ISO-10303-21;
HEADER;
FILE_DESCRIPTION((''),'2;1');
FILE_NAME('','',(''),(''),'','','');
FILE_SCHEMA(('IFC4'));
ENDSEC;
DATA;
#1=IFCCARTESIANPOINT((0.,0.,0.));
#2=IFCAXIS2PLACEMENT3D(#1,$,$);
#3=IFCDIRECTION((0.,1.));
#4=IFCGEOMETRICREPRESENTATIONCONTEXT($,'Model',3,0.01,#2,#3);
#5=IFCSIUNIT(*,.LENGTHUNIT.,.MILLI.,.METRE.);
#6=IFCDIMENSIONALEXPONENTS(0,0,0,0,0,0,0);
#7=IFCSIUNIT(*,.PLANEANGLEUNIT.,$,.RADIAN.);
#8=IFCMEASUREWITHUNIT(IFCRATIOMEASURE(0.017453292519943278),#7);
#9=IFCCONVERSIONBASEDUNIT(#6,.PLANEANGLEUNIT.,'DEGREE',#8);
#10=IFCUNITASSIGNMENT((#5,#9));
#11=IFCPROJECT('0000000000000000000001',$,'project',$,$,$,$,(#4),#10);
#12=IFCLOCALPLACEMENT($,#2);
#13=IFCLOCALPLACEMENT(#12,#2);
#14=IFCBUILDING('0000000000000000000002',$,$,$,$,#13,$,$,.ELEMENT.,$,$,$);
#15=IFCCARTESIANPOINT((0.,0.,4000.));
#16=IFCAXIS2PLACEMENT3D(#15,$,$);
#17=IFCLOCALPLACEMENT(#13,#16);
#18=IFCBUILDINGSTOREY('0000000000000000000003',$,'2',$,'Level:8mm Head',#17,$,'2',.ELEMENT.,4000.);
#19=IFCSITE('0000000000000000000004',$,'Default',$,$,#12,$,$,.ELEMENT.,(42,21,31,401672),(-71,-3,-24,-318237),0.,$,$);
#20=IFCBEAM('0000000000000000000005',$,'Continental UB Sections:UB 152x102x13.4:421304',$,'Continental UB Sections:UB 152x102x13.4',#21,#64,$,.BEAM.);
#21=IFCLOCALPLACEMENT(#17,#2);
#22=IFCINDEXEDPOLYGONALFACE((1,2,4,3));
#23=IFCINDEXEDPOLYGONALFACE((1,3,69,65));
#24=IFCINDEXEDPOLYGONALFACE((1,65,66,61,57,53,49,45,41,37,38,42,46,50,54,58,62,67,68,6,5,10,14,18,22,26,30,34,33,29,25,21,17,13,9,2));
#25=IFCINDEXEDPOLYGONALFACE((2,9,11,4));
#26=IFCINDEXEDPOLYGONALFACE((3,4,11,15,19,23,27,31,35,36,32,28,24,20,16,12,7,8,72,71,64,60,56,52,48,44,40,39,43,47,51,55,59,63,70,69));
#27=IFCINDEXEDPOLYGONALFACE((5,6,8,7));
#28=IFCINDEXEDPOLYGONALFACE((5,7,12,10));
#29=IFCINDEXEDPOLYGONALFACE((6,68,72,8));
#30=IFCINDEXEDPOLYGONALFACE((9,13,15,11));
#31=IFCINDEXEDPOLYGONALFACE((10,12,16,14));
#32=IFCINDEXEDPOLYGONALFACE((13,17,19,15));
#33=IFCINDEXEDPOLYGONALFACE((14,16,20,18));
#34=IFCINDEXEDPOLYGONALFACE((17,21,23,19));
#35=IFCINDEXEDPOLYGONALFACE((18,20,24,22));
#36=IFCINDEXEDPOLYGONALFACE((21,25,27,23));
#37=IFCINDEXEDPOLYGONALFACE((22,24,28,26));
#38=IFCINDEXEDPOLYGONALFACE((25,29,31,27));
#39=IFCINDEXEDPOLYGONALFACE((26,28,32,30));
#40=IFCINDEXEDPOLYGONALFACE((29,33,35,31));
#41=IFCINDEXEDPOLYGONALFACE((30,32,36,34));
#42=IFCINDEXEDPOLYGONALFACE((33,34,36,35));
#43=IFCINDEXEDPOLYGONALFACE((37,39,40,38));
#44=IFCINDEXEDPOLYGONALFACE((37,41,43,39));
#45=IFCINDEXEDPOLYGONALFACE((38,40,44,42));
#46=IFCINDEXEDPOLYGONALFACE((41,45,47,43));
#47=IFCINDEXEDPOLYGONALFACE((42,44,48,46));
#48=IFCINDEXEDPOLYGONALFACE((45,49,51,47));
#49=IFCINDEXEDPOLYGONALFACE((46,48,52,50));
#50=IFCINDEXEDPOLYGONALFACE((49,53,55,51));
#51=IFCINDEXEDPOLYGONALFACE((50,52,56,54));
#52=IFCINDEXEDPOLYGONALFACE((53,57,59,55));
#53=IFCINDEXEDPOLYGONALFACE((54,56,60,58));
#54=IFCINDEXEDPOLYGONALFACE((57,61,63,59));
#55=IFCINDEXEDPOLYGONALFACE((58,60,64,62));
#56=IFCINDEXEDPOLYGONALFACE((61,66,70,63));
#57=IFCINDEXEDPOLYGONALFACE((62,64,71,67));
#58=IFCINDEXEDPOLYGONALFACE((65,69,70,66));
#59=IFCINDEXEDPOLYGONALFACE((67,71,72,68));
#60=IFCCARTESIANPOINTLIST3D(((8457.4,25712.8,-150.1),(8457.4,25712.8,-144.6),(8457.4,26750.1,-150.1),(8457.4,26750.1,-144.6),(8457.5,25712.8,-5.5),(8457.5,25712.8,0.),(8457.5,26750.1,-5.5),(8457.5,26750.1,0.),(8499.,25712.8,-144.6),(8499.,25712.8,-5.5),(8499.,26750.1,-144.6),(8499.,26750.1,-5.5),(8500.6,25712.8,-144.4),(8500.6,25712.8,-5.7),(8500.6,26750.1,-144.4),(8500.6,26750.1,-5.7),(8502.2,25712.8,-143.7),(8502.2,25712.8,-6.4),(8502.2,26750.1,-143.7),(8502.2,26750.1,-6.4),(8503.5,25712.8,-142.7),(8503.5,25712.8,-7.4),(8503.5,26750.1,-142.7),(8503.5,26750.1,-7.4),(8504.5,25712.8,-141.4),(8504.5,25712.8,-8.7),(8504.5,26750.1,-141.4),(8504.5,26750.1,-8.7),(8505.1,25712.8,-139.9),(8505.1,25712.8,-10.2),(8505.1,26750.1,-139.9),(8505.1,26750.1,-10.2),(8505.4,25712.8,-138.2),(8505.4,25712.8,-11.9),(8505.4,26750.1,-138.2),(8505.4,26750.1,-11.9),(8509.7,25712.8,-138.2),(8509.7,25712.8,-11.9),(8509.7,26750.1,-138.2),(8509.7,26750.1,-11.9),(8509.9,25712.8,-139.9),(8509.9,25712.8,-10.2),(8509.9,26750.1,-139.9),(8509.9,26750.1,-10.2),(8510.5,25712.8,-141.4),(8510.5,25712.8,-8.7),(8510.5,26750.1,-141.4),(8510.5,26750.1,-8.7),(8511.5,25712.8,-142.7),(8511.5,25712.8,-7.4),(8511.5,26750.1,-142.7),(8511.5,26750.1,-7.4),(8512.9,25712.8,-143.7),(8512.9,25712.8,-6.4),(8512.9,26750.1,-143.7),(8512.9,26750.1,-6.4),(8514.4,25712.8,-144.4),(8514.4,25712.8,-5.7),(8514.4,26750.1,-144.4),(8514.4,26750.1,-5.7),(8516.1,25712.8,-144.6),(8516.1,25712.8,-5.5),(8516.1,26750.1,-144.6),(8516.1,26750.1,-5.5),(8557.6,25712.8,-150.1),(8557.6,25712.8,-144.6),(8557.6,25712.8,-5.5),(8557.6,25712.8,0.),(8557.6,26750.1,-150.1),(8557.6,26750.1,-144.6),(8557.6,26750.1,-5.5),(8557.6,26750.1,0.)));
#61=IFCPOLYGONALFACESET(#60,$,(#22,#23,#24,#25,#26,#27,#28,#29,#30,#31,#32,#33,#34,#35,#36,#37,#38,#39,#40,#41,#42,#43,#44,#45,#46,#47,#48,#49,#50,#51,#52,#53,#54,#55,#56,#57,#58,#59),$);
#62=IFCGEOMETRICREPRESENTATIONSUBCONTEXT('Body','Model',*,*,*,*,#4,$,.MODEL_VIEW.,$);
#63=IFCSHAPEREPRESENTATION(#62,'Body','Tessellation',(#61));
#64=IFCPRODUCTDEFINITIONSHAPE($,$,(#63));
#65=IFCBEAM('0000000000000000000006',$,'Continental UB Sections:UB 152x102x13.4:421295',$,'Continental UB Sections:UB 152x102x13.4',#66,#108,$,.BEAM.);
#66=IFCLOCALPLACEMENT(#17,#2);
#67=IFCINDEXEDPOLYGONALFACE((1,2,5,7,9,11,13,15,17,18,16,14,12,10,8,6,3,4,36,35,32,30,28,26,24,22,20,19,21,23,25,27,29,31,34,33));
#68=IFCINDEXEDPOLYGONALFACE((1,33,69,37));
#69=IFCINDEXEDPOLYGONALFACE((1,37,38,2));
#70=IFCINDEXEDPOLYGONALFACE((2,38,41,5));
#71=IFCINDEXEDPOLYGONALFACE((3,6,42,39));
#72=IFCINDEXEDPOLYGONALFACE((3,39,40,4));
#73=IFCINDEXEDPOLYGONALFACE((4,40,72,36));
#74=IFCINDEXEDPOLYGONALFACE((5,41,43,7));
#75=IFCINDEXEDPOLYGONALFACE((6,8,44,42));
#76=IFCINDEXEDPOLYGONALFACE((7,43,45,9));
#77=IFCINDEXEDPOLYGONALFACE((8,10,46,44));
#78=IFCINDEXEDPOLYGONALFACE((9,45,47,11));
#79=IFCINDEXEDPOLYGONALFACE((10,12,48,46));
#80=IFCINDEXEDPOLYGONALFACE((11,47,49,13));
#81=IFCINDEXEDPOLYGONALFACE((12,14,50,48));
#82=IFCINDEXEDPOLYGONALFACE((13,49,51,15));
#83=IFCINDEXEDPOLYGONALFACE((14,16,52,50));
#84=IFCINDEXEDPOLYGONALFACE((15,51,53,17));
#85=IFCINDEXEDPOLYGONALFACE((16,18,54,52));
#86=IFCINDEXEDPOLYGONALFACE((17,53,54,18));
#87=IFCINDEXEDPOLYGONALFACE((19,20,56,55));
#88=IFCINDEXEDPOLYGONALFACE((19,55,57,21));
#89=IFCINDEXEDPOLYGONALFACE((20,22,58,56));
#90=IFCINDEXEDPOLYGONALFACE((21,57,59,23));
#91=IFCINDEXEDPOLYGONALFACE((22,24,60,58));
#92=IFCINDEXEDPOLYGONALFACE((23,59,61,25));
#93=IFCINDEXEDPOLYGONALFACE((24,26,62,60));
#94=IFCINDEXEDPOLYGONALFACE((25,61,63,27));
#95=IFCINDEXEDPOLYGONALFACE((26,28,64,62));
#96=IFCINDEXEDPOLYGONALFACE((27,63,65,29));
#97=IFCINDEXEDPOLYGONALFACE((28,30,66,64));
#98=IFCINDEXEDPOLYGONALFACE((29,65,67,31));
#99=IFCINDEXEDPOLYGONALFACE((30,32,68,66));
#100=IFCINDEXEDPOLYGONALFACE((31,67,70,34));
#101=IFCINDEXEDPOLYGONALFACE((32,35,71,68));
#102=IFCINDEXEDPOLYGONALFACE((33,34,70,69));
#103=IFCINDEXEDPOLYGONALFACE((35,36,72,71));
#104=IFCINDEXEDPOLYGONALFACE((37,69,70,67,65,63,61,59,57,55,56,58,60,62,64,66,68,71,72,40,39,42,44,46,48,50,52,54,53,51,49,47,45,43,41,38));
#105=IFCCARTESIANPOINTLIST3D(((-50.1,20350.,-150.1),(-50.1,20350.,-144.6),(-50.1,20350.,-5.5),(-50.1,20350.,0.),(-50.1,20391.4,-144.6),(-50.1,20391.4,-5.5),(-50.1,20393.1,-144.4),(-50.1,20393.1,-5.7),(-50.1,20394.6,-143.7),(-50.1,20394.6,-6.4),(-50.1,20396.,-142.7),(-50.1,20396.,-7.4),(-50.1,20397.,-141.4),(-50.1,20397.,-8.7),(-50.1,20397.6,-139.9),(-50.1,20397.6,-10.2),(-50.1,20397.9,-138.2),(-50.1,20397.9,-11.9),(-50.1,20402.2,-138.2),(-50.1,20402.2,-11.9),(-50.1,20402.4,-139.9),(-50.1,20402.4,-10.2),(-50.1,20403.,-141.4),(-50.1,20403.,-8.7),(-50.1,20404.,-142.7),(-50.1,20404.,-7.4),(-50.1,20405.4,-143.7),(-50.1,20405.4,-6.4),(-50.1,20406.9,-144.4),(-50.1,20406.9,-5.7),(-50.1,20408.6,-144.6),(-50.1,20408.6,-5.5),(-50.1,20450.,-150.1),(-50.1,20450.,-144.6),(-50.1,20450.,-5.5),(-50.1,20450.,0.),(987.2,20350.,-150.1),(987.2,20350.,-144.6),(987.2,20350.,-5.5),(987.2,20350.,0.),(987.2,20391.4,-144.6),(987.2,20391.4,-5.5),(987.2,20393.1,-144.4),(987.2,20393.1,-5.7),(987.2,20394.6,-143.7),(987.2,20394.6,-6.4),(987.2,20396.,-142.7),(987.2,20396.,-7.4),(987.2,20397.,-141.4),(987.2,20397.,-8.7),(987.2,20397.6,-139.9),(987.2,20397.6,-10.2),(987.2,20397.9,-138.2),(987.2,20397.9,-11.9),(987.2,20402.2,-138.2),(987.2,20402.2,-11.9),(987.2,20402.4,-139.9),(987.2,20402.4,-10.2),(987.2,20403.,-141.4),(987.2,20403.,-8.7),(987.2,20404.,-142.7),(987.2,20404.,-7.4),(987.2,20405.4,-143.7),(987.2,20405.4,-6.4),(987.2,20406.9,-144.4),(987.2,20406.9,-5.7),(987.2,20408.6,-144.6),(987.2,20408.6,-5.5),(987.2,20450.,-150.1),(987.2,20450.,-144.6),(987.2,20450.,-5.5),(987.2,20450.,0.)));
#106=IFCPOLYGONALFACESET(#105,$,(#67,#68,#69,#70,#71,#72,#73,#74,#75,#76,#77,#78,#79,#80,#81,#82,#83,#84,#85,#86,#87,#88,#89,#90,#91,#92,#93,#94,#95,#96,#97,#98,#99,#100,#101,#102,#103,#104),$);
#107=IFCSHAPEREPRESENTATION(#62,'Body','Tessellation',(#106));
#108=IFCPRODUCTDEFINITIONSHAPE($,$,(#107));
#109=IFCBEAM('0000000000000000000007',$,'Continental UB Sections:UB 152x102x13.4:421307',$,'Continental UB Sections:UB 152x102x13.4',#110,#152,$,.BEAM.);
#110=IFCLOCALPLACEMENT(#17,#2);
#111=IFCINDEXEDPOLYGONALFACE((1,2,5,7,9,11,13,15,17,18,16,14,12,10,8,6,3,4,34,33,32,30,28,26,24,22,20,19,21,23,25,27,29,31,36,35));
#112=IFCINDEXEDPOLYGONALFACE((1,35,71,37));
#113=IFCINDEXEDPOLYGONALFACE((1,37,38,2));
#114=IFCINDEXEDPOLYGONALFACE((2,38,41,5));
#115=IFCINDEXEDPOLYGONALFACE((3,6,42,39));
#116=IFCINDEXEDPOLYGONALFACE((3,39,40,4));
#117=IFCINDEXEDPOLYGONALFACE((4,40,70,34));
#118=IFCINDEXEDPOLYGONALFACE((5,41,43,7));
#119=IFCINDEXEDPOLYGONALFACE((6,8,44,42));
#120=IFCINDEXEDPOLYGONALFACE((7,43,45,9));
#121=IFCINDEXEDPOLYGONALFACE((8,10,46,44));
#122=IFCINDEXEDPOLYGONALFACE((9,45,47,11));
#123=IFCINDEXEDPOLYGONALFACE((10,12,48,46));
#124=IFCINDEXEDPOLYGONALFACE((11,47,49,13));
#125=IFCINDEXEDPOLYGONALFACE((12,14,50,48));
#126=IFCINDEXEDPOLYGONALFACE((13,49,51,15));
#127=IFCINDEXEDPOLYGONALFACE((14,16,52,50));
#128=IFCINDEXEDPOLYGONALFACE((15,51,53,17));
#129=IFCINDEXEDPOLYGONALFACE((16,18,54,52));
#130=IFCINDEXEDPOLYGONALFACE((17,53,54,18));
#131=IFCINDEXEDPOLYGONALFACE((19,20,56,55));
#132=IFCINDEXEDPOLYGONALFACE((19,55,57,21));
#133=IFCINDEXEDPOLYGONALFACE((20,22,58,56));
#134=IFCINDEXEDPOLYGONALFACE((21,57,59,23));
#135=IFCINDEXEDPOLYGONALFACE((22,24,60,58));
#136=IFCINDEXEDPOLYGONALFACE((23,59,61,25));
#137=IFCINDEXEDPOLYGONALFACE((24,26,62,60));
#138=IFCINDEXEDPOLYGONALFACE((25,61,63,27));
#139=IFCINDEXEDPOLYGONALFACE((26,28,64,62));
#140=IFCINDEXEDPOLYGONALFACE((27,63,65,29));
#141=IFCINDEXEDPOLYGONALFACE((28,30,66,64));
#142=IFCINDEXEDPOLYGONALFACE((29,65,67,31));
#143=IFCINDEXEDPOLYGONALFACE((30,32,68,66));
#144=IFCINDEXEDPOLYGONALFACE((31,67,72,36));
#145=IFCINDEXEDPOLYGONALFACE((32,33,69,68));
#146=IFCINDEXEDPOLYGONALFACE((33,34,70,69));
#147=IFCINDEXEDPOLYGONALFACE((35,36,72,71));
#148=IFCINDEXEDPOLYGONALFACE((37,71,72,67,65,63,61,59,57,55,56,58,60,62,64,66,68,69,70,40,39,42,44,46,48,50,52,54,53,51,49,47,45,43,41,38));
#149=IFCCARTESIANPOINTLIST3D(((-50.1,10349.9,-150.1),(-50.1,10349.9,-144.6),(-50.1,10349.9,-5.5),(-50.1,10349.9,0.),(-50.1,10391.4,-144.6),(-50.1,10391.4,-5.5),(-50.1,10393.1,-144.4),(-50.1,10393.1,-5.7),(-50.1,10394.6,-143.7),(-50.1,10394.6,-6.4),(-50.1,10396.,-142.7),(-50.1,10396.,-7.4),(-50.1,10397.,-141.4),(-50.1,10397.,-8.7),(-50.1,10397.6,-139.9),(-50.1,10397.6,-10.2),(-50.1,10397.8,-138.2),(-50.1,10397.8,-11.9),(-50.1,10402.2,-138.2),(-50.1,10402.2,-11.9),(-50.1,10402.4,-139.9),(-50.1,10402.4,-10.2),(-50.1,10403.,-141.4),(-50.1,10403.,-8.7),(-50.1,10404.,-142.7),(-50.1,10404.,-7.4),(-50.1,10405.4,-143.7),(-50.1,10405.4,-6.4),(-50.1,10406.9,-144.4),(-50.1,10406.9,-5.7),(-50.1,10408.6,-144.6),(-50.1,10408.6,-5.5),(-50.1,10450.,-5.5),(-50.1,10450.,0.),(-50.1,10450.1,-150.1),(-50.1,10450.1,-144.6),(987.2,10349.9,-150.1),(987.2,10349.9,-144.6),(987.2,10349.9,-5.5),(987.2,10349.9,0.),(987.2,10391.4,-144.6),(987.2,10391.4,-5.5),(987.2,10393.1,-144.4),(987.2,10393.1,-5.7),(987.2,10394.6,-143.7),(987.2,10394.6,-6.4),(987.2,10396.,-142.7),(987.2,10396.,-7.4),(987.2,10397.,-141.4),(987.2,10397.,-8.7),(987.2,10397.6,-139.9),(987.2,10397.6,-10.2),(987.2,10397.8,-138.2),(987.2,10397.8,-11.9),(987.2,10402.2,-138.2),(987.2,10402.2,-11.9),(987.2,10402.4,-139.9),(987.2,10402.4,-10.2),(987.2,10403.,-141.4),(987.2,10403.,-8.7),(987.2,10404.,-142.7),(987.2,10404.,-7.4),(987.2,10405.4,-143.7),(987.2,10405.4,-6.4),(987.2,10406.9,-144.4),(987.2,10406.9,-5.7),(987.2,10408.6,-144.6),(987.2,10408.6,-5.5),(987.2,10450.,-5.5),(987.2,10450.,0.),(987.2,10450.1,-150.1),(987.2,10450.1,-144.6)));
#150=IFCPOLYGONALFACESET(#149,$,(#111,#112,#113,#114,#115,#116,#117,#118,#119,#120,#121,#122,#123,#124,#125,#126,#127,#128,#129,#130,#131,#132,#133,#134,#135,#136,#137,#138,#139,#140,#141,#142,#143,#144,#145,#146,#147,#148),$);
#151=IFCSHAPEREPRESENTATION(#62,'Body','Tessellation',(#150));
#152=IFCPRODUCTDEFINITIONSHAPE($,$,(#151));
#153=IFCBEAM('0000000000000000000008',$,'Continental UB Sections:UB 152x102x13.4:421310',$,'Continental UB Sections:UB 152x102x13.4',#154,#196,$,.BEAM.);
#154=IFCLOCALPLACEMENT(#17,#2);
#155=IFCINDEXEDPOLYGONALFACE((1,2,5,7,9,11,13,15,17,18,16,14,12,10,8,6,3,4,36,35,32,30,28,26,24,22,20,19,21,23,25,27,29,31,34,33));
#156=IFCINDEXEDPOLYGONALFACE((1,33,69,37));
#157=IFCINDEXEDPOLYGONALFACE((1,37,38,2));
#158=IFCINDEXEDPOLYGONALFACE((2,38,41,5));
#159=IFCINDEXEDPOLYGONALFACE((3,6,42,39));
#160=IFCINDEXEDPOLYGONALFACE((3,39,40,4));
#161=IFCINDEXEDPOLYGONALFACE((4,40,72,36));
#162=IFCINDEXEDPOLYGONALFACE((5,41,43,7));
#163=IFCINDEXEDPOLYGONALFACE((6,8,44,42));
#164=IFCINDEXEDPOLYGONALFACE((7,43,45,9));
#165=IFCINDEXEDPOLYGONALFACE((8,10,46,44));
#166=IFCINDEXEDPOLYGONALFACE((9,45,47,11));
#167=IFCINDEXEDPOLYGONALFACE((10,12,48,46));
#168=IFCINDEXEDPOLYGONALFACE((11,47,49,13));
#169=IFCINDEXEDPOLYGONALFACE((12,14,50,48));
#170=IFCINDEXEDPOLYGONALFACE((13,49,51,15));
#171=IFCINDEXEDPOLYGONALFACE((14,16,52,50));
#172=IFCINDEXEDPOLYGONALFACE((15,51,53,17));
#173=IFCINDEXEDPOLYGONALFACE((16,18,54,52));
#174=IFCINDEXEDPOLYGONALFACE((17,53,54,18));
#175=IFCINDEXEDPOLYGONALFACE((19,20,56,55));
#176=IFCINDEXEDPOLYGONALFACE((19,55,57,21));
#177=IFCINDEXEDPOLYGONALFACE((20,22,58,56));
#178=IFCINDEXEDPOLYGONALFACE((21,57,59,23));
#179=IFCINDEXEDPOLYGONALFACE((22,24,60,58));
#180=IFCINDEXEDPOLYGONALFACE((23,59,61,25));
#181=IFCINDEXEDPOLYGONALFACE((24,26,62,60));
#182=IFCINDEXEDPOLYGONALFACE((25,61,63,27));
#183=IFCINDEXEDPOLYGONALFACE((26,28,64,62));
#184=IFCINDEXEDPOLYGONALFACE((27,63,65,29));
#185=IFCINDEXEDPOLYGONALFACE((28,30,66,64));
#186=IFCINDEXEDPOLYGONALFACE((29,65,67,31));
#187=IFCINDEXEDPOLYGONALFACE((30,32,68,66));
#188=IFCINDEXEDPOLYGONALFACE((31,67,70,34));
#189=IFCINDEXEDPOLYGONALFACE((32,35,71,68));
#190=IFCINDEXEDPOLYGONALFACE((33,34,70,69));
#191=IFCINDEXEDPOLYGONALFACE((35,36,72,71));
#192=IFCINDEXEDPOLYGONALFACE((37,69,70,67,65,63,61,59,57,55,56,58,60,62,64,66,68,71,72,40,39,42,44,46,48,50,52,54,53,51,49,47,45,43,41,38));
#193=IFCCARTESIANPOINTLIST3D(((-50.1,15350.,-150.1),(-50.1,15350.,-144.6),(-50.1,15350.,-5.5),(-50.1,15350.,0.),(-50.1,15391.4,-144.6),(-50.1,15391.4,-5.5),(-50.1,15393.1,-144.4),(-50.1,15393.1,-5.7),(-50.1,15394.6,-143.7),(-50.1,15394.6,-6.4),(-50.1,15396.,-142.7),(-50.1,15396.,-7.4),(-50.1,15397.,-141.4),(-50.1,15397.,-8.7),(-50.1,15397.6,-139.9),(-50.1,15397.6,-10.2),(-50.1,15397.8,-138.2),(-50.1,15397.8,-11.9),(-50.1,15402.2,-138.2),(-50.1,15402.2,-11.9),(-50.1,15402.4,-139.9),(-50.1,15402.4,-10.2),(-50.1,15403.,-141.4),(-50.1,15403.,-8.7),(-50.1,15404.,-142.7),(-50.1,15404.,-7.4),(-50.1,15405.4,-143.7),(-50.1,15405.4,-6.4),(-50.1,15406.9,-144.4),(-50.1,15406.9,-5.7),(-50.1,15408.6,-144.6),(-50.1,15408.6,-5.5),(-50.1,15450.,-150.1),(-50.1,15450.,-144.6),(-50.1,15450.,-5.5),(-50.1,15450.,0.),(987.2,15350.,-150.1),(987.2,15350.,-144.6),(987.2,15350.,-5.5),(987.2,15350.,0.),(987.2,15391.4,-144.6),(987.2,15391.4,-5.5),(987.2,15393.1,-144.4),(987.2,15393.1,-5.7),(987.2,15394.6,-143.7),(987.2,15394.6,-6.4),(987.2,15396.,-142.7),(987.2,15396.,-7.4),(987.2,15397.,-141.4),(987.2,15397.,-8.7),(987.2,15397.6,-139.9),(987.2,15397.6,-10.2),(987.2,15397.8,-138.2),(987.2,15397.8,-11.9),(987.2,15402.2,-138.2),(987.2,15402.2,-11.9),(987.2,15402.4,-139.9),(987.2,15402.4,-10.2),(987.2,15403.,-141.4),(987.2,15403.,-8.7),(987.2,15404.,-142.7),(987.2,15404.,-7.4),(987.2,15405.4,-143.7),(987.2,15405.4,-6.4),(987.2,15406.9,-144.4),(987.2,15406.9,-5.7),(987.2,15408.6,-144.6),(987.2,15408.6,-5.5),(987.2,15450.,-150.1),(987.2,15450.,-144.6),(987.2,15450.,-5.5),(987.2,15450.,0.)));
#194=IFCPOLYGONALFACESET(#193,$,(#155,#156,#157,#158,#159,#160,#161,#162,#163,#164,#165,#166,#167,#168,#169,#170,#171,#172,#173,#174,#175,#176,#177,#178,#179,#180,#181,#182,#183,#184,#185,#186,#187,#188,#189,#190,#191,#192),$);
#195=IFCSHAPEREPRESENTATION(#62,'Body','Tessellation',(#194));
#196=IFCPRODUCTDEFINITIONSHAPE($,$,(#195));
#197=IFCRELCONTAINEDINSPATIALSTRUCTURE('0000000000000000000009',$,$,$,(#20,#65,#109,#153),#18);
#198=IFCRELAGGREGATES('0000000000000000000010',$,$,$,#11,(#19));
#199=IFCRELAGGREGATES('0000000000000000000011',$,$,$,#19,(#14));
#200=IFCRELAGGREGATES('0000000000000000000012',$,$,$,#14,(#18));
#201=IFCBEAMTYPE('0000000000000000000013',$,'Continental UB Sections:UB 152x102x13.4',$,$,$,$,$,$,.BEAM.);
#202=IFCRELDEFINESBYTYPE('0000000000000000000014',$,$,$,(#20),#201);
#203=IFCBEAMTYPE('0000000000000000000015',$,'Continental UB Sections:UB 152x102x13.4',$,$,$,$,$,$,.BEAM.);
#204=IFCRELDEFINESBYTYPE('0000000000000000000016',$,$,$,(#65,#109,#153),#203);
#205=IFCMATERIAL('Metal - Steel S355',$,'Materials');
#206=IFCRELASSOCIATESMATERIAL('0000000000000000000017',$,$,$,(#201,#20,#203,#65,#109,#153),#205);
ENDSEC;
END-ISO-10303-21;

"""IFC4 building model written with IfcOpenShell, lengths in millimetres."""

from ifc_helpers import new_model, entity, si_unit, converted_unit, direction, frame, origin, place, context, subcontext, project, spatial, line, arc, indexed_curve, outline, extrude, source, transform, mapped, material, type_object, type_shapes, element, save


model = new_model("IFC4")

# Units and contexts
model_context = context("Model", 3, precision=0.01, world=origin(), true_north=direction((0.0, 1.0)))
body_context = subcontext(model_context, "Body", "Model", "MODEL_VIEW")
ifc_project = project(units=[si_unit("LENGTHUNIT", "METRE", prefix="MILLI"), converted_unit("PLANEANGLEUNIT", "DEGREE", entity("IfcRatioMeasure", 0.017453292519943278), si_unit("PLANEANGLEUNIT", "RADIAN"), dimensions=[0, 0, 0, 0, 0, 0, 0])], contexts=[model_context])

# Site, building, storey
site_placement = place(None, origin())
site = spatial("IfcSite", under=ifc_project, at=site_placement, Name="Default", CompositionType="ELEMENT", RefLatitude=(42, 21, 31, 401672), RefLongitude=(-71, -3, -24, -318237), RefElevation=0.0)
building_placement = place(site_placement, origin())
building = spatial("IfcBuilding", under=site, at=building_placement, CompositionType="ELEMENT")
storey_placement = place(building_placement, frame((0.0, 0.0, 4000.0)))
storey = spatial("IfcBuildingStorey", under=building, at=storey_placement, Name="2", ObjectType="Level:8mm Head", LongName="2", CompositionType="ELEMENT", Elevation=4000.0)

# Beams
ifc_material_1 = material(Name="Metal - Steel S355", Category="Materials")
beam_type_1 = type_object("IfcBeamType", Name="Continental UB Sections:UB 152x102x13.4", PredefinedType="BEAM", material=ifc_material_1)
shared_shape_1 = source(origin(), body_context, "Body", "SweptSolid", [
    extrude(outline(indexed_curve([(-75.0, -50.1), (-69.6, -50.1), (-69.6, -8.5), (-67.7, -4.0), (-63.2, -2.1), (63.1, -2.1), (67.7, -4.0), (69.5, -8.5), (69.5, -50.1), (75.1, -50.1), (75.1, 50.1), (69.5, 50.1), (69.5, 8.6), (67.7, 4.0), (63.1, 2.2), (-63.2, 2.2), (-67.7, 4.0), (-69.6, 8.6), (-69.6, 50.0), (-75.0, 50.0)], segments=[line(1, 2, 3), arc(3, 4, 5), line(5, 6), arc(6, 7, 8), line(8, 9, 10, 11, 12, 13), arc(13, 14, 15), line(15, 16), arc(16, 17, 18), line(18, 19, 20, 1)], self_intersect=False)), frame((-487.2, 0.0, 0.0), z_axis=(1.0, 0.0, 0.0), x_axis=(0.0, 0.0, -1.0)), (0.0, 0.0, 1.0), 1037.3),
])
type_shapes(beam_type_1, [shared_shape_1])
for number, where, z_axis, x_axis, name in (
    (1, (8507.5, 26200.0, -75.1), (0.0, 0.0, 1.0), (0.0, 1.0, 0.0), "Continental UB Sections:UB 152x102x13.4:421304"),
):
    element("IfcBeam", number, at=place(storey_placement, frame(where, z_axis=z_axis, x_axis=x_axis)), inside=storey, type_object=beam_type_1, material=ifc_material_1, Name=name, ObjectType="Continental UB Sections:UB 152x102x13.4", PredefinedType="BEAM", context=body_context, shape_type="MappedRepresentation", body=[
        mapped(shared_shape_1, transform((0.0, 0.0, 0.0), scale=1.0)),
    ])
beam_type_2 = type_object("IfcBeamType", Name="Continental UB Sections:UB 152x102x13.4", PredefinedType="BEAM", material=ifc_material_1)
shared_shape_2 = source(origin(), body_context, "Body", "SweptSolid", [
    extrude(outline(indexed_curve([(-75.0, -50.1), (-69.6, -50.1), (-69.6, -8.5), (-67.7, -4.0), (-63.2, -2.1), (63.1, -2.1), (67.7, -4.0), (69.5, -8.5), (69.5, -50.1), (75.1, -50.1), (75.1, 50.1), (69.5, 50.1), (69.5, 8.6), (67.7, 4.0), (63.1, 2.2), (-63.2, 2.2), (-67.7, 4.0), (-69.6, 8.6), (-69.6, 50.0), (-75.0, 50.0)], segments=[line(1, 2, 3), arc(3, 4, 5), line(5, 6), arc(6, 7, 8), line(8, 9, 10, 11, 12, 13), arc(13, 14, 15), line(15, 16), arc(16, 17, 18), line(18, 19, 20, 1)], self_intersect=False)), frame((-550.1, 0.0, 0.0), z_axis=(1.0, 0.0, 0.0), x_axis=(0.0, 0.0, -1.0)), (0.0, 0.0, 1.0), 1037.3),
])
type_shapes(beam_type_2, [shared_shape_2])
for number, where, name in (
    (2, (500.0, 20400.0, -75.1), "Continental UB Sections:UB 152x102x13.4:421295"),
    (3, (500.0, 10400.0, -75.1), "Continental UB Sections:UB 152x102x13.4:421307"),
    (4, (500.0, 15400.0, -75.1), "Continental UB Sections:UB 152x102x13.4:421310"),
):
    element("IfcBeam", number, at=place(storey_placement, frame(where)), inside=storey, type_object=beam_type_2, material=ifc_material_1, Name=name, ObjectType="Continental UB Sections:UB 152x102x13.4", PredefinedType="BEAM", context=body_context, shape_type="MappedRepresentation", body=[
        mapped(shared_shape_2, transform((0.0, 0.0, 0.0), scale=1.0)),
    ])

save(model, "model.ifc")
